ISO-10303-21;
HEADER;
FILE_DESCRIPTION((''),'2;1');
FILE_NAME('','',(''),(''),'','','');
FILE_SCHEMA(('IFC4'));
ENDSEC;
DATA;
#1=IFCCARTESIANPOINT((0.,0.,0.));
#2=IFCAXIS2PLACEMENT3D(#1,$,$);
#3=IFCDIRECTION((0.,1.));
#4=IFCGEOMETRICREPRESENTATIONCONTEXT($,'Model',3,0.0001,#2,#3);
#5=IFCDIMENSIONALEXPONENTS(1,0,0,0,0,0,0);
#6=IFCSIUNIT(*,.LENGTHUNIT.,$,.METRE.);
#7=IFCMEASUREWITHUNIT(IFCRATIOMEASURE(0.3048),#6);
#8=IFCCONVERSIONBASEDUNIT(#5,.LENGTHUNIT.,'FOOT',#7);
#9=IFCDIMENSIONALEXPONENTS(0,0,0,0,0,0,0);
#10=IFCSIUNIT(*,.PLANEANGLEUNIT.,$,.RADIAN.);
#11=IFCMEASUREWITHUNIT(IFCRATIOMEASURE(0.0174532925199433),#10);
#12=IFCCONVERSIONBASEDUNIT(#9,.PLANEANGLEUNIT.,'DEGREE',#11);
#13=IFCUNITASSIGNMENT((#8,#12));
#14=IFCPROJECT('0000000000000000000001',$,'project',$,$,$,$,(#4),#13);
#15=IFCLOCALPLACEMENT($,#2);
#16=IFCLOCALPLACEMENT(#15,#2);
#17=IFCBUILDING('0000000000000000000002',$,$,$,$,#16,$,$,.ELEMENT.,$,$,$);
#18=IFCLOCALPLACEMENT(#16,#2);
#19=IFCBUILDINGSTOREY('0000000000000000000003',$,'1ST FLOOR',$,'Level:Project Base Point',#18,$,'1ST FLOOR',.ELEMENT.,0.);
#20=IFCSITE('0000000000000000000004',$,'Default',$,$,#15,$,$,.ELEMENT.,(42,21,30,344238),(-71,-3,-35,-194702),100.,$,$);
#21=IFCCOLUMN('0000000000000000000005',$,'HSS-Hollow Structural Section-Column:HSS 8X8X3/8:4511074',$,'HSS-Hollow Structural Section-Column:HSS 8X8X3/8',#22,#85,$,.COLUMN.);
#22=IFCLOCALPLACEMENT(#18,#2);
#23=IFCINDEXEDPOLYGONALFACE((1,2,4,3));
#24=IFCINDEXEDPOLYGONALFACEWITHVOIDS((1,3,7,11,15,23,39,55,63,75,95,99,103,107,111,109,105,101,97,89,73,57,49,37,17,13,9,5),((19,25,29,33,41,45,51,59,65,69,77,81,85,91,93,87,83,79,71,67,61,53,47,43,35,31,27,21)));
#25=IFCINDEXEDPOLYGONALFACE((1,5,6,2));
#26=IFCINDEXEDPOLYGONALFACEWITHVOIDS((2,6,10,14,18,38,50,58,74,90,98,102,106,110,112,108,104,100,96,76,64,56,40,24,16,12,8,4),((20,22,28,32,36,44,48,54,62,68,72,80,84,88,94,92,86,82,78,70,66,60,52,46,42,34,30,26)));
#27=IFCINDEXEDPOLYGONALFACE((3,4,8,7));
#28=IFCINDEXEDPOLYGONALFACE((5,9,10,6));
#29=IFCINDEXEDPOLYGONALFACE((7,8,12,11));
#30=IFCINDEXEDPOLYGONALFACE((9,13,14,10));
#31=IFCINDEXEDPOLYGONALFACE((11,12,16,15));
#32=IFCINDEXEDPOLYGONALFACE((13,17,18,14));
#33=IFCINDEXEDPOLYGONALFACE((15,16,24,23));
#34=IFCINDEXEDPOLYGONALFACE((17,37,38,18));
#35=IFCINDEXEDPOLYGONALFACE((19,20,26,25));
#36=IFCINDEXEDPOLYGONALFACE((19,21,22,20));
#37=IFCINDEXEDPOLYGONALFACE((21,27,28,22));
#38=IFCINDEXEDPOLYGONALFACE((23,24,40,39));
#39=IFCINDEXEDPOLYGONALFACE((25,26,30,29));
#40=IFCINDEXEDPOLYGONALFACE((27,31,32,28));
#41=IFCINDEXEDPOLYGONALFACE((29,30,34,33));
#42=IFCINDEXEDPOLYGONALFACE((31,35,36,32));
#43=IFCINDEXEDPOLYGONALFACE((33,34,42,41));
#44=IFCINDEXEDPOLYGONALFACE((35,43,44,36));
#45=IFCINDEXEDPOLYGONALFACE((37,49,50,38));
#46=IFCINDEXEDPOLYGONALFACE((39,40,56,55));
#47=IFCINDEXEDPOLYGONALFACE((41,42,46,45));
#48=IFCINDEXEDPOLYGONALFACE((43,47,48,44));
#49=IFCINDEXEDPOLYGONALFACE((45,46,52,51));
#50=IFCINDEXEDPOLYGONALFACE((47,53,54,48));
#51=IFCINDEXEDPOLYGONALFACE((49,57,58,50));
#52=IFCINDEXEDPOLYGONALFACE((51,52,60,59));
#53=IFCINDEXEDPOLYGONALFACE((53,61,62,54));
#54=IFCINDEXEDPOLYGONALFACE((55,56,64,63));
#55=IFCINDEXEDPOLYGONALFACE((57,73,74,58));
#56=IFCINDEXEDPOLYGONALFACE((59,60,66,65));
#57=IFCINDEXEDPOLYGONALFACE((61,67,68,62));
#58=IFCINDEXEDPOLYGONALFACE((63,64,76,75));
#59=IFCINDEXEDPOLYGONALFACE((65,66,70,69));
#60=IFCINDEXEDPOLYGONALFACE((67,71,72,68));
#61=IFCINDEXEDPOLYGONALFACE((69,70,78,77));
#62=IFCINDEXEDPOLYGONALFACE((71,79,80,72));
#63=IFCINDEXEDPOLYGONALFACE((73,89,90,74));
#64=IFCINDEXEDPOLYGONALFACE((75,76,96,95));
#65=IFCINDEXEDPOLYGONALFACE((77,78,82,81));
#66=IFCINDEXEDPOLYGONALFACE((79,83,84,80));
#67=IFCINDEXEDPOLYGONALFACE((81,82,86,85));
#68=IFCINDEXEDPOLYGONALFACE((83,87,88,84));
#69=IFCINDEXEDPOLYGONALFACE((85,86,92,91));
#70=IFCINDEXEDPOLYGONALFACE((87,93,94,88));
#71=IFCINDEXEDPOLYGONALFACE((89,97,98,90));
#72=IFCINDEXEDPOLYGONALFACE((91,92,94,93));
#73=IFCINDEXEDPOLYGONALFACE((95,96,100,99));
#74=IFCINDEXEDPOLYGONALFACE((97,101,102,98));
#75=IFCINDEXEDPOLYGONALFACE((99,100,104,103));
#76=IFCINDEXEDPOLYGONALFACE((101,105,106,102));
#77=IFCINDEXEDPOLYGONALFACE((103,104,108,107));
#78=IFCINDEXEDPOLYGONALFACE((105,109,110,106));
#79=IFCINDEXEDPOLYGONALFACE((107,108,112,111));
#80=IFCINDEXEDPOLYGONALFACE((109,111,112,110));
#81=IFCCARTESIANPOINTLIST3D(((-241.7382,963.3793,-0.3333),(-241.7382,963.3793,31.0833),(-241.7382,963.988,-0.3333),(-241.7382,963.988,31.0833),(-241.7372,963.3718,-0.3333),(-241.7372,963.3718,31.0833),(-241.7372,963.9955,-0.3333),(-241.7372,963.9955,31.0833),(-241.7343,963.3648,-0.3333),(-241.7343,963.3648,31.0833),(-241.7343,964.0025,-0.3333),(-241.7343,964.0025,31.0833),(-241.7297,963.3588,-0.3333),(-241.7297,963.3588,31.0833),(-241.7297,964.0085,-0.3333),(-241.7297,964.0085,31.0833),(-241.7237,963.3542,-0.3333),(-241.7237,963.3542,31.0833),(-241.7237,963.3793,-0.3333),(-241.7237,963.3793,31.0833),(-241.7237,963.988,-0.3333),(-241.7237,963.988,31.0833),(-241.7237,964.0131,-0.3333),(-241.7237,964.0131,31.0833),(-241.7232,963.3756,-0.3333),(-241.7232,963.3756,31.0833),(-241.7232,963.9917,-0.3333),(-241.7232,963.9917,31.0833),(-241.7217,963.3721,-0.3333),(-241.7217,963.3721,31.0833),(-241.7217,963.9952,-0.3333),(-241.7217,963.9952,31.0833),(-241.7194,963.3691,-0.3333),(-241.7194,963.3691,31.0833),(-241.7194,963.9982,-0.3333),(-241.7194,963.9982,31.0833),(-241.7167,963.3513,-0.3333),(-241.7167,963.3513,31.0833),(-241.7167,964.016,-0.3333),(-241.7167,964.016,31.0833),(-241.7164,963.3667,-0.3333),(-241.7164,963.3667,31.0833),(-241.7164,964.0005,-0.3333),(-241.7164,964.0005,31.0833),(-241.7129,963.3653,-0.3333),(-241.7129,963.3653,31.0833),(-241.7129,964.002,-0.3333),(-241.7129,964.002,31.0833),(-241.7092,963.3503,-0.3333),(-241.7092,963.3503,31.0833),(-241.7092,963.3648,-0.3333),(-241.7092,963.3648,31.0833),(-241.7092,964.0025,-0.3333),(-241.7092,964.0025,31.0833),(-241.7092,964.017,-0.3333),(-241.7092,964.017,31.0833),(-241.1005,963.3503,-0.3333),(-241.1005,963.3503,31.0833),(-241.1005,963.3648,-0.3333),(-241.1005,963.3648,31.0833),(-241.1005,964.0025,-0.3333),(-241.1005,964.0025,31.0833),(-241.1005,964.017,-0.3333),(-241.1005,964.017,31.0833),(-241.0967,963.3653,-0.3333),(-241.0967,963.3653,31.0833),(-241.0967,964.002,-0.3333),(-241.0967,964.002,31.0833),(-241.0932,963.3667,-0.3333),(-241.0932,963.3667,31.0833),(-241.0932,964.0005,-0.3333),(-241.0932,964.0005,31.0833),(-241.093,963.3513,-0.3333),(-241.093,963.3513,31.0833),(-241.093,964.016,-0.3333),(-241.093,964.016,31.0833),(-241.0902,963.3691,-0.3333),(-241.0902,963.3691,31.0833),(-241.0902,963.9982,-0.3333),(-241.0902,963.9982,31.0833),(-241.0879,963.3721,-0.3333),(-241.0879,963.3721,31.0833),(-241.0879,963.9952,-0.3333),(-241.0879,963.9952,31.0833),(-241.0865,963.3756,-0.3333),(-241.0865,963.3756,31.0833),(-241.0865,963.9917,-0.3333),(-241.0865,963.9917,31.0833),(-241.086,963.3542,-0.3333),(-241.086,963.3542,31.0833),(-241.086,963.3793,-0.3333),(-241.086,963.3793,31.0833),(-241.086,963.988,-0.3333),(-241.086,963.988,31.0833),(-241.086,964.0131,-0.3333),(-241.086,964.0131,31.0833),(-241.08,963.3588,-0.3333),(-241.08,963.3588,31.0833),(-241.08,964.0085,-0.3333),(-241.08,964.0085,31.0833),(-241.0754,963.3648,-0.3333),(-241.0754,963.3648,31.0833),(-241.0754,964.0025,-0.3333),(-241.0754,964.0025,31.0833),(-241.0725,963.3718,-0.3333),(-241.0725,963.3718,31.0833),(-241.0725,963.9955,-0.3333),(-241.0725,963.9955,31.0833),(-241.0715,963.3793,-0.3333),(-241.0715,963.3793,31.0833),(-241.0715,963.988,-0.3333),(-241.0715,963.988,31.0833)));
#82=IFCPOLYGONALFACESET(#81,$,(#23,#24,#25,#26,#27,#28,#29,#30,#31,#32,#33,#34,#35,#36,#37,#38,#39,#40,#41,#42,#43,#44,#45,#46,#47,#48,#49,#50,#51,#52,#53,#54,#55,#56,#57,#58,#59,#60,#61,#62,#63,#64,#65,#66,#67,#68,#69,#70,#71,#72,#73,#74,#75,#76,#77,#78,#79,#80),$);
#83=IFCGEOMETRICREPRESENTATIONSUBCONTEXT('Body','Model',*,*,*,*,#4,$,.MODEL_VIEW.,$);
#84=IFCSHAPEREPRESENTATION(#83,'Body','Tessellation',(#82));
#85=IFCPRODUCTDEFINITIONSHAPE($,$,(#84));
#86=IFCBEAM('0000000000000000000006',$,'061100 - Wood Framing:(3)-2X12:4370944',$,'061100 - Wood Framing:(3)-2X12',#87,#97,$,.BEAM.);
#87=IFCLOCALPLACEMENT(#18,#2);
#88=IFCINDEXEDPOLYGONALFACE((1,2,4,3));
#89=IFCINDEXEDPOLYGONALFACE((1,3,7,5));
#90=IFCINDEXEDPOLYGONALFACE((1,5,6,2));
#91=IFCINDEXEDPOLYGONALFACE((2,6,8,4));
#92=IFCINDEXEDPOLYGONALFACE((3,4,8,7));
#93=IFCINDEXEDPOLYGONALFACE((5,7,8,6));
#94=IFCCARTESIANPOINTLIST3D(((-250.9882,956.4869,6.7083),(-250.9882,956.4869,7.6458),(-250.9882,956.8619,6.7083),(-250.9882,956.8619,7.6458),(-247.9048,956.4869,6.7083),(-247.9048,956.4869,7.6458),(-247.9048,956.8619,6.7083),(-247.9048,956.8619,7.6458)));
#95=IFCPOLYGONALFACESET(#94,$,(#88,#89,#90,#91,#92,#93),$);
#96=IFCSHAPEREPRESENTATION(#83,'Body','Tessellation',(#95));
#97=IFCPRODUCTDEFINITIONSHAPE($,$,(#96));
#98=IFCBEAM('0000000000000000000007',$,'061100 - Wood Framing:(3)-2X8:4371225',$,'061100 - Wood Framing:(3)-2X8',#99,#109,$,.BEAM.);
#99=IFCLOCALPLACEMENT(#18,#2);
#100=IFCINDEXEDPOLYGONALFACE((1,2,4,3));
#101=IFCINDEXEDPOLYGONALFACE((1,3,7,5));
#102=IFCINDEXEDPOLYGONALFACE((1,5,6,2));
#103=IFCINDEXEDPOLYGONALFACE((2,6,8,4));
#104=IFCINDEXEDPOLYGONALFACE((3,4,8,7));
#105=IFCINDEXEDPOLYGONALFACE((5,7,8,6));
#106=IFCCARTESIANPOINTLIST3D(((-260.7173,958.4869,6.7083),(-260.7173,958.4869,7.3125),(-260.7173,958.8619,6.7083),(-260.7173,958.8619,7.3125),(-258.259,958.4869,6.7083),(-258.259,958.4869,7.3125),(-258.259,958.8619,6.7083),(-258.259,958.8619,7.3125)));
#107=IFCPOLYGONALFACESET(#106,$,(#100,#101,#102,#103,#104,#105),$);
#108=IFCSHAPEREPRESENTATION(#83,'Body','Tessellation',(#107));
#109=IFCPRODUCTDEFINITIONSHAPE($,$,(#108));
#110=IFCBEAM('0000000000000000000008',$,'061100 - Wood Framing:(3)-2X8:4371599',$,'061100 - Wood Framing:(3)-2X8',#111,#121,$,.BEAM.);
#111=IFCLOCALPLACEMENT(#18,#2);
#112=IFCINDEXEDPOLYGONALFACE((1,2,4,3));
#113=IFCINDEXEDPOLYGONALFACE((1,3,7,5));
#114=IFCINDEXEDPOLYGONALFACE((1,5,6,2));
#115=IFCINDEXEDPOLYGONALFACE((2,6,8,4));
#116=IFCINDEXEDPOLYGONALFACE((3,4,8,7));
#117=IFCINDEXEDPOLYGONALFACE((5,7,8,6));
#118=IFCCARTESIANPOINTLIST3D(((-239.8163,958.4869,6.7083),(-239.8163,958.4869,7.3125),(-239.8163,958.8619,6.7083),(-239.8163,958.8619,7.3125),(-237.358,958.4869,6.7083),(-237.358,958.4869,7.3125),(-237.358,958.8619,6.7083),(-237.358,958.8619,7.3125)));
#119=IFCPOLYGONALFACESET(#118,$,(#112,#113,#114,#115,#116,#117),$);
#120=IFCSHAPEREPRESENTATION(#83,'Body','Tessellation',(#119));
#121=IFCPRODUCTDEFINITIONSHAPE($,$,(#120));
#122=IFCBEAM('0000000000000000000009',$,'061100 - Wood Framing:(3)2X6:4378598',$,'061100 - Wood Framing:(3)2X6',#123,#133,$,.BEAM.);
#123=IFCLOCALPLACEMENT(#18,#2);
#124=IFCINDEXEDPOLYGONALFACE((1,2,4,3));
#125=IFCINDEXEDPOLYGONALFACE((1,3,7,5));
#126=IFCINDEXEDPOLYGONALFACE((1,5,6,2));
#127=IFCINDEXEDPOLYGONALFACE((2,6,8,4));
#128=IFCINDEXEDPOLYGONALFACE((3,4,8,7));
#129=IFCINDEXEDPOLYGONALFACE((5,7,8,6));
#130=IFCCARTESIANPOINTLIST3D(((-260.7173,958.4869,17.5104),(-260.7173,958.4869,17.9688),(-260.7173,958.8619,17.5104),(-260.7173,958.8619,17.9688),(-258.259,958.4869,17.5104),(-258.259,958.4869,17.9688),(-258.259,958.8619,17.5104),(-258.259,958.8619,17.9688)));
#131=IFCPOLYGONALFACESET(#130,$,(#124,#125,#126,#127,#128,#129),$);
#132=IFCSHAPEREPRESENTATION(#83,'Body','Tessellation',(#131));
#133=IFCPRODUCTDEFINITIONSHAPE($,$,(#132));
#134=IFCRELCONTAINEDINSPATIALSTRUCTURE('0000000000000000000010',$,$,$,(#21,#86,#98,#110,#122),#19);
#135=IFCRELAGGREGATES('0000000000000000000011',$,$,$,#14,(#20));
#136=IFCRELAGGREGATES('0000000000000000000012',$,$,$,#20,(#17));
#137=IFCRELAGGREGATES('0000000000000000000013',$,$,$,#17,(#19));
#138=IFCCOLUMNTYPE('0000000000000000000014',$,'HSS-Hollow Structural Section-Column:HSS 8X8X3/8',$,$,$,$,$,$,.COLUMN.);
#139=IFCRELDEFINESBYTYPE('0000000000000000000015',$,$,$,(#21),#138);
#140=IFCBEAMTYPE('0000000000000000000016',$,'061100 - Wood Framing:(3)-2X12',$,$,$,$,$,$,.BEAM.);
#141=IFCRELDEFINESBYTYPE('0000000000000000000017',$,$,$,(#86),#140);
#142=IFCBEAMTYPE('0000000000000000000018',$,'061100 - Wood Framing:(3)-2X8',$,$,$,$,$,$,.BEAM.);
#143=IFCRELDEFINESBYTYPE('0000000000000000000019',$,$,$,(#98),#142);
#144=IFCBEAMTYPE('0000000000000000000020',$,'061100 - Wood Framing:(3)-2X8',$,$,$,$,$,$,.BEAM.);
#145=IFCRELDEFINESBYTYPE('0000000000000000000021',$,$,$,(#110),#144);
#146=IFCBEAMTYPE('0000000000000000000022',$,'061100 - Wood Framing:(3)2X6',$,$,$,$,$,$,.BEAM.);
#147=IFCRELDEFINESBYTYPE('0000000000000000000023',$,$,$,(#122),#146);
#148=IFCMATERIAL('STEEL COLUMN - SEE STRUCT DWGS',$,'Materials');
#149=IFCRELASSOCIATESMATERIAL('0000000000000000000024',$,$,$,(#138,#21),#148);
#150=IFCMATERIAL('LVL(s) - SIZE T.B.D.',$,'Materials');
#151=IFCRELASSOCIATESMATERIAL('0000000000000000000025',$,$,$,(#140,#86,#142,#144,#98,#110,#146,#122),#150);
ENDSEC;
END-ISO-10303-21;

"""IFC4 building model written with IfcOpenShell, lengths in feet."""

from ifc_helpers import new_model, entity, si_unit, converted_unit, direction, frame, frame_2d, origin, origin_2d_with_axis, place, context, subcontext, project, spatial, polyline, circle_curve, parameter, trimmed, segment, composite_curve, rectangle, outline, extrude, source, transform, mapped, material, material_profile, profile_set, profile_usage, type_object, type_shapes, element, save


model = new_model("IFC4")

# Units and contexts
model_context = context("Model", 3, precision=0.0001, world=origin(), true_north=direction((0.0, 1.0)))
body_context = subcontext(model_context, "Body", "Model", "MODEL_VIEW")
ifc_project = project(units=[converted_unit("LENGTHUNIT", "FOOT", entity("IfcRatioMeasure", 0.3048), si_unit("LENGTHUNIT", "METRE"), dimensions=[1, 0, 0, 0, 0, 0, 0]), converted_unit("PLANEANGLEUNIT", "DEGREE", entity("IfcRatioMeasure", 0.0174532925199433), si_unit("PLANEANGLEUNIT", "RADIAN"), dimensions=[0, 0, 0, 0, 0, 0, 0])], contexts=[model_context])

# Site, building, storey
site_placement = place(None, origin())
site = spatial("IfcSite", under=ifc_project, at=site_placement, Name="Default", CompositionType="ELEMENT", RefLatitude=(42, 21, 30, 344238), RefLongitude=(-71, -3, -35, -194702), RefElevation=100.0)
building_placement = place(site_placement, origin())
building = spatial("IfcBuilding", under=site, at=building_placement, CompositionType="ELEMENT")
storey_placement = place(building_placement, origin())
storey = spatial("IfcBuildingStorey", under=building, at=storey_placement, Name="1ST FLOOR", ObjectType="Level:Project Base Point", LongName="1ST FLOOR", CompositionType="ELEMENT", Elevation=0.0)

# Column
ifc_material_1 = material(Name="STEEL COLUMN - SEE STRUCT DWGS", Category="Materials")
ifc_material_profile_1 = material_profile(ifc_material_1, outline(composite_curve([segment(polyline([(-0.3043, -0.3333), (0.3043, -0.3333)]), True, "CONTINUOUS"), segment(trimmed(circle_curve(frame_2d((0.3043, -0.3043), x_axis=(-1.0, 0.0)), 0.029), [parameter(90.0)], [parameter(180.0)], True, "PARAMETER"), True, "CONTINUOUS"), segment(polyline([(0.3333, -0.3043), (0.3333, 0.3043)]), True, "CONTINUOUS"), segment(trimmed(circle_curve(frame_2d((0.3043, 0.3043), x_axis=(-1.0, 0.0)), 0.029), [parameter(180.0)], [parameter(270.0)], True, "PARAMETER"), True, "CONTINUOUS"), segment(polyline([(0.3043, 0.3333), (-0.3043, 0.3333)]), True, "CONTINUOUS"), segment(trimmed(circle_curve(frame_2d((-0.3043, 0.3043), x_axis=(-1.0, 0.0)), 0.029), [parameter(270.0)], [parameter(360.0)], True, "PARAMETER"), True, "CONTINUOUS"), segment(polyline([(-0.3333, 0.3043), (-0.3333, -0.3043)]), True, "CONTINUOUS"), segment(trimmed(circle_curve(frame_2d((-0.3043, -0.3043), x_axis=(-1.0, 0.0)), 0.029), [parameter(360.0)], [parameter(90.0)], True, "PARAMETER"), True, "CONTINUOUS")], self_intersect=False), holes=[composite_curve([segment(trimmed(circle_curve(frame_2d((-0.3043, -0.3043), x_axis=(-1.0, 0.0)), 0.0145), [parameter(0.0)], [parameter(90.0)], True, "PARAMETER"), False, "CONTINUOUS"), segment(polyline([(-0.3188, -0.3043), (-0.3188, 0.3043)]), True, "CONTINUOUS"), segment(trimmed(circle_curve(frame_2d((-0.3043, 0.3043), x_axis=(-1.0, 0.0)), 0.0145), [parameter(270.0)], [parameter(0.0)], True, "PARAMETER"), False, "CONTINUOUS"), segment(polyline([(-0.3043, 0.3188), (0.3043, 0.3188)]), True, "CONTINUOUS"), segment(trimmed(circle_curve(frame_2d((0.3043, 0.3043), x_axis=(-1.0, 0.0)), 0.0145), [parameter(180.0)], [parameter(270.0)], True, "PARAMETER"), False, "CONTINUOUS"), segment(polyline([(0.3188, 0.3043), (0.3188, -0.3043)]), True, "CONTINUOUS"), segment(trimmed(circle_curve(frame_2d((0.3043, -0.3043), x_axis=(-1.0, 0.0)), 0.0145), [parameter(90.0)], [parameter(180.0)], True, "PARAMETER"), False, "CONTINUOUS"), segment(polyline([(0.3043, -0.3188), (-0.3043, -0.3188)]), True, "CONTINUOUS")], self_intersect=False)]), Name="HSS 8X8X3/8")
ifc_profile_set_1 = profile_set([ifc_material_profile_1], Name="HSS 8X8X3/8")
ifc_profile_usage_1 = profile_usage(ifc_profile_set_1)
column_type_1 = type_object("IfcColumnType", Name="HSS-Hollow Structural Section-Column:HSS 8X8X3/8", PredefinedType="COLUMN", material=ifc_profile_set_1)
shared_shape_1 = source(origin(), body_context, "Body", "SweptSolid", [
    extrude(outline(composite_curve([segment(trimmed(circle_curve(frame_2d((0.3043, -0.3043), x_axis=(1.0, 0.0)), 0.029), [parameter(270.0)], [parameter(0.0)], True, "PARAMETER"), True, "CONTINUOUS"), segment(polyline([(0.3333, -0.3043), (0.3333, 0.3043)]), True, "CONTINUOUS"), segment(trimmed(circle_curve(frame_2d((0.3043, 0.3043), x_axis=(1.0, 0.0)), 0.029), [parameter(0.0)], [parameter(90.0)], True, "PARAMETER"), True, "CONTINUOUS"), segment(polyline([(0.3043, 0.3333), (-0.3043, 0.3333)]), True, "CONTINUOUS"), segment(trimmed(circle_curve(frame_2d((-0.3043, 0.3043), x_axis=(1.0, 0.0)), 0.029), [parameter(90.0)], [parameter(180.0)], True, "PARAMETER"), True, "CONTINUOUS"), segment(polyline([(-0.3333, 0.3043), (-0.3333, -0.3043)]), True, "CONTINUOUS"), segment(trimmed(circle_curve(frame_2d((-0.3043, -0.3043), x_axis=(1.0, 0.0)), 0.029), [parameter(180.0)], [parameter(270.0)], True, "PARAMETER"), True, "CONTINUOUS"), segment(polyline([(-0.3043, -0.3333), (0.3043, -0.3333)]), True, "CONTINUOUS")], self_intersect=False), holes=[composite_curve([segment(polyline([(0.3043, -0.3188), (-0.3043, -0.3188)]), True, "CONTINUOUS"), segment(trimmed(circle_curve(frame_2d((-0.3043, -0.3043), x_axis=(1.0, 0.0)), 0.0145), [parameter(180.0)], [parameter(270.0)], True, "PARAMETER"), False, "CONTINUOUS"), segment(polyline([(-0.3188, -0.3043), (-0.3188, 0.3043)]), True, "CONTINUOUS"), segment(trimmed(circle_curve(frame_2d((-0.3043, 0.3043), x_axis=(1.0, 0.0)), 0.0145), [parameter(90.0)], [parameter(180.0)], True, "PARAMETER"), False, "CONTINUOUS"), segment(polyline([(-0.3043, 0.3188), (0.3043, 0.3188)]), True, "CONTINUOUS"), segment(trimmed(circle_curve(frame_2d((0.3043, 0.3043), x_axis=(1.0, 0.0)), 0.0145), [parameter(0.0)], [parameter(90.0)], True, "PARAMETER"), False, "CONTINUOUS"), segment(polyline([(0.3188, 0.3043), (0.3188, -0.3043)]), True, "CONTINUOUS"), segment(trimmed(circle_curve(frame_2d((0.3043, -0.3043), x_axis=(1.0, 0.0)), 0.0145), [parameter(270.0)], [parameter(0.0)], True, "PARAMETER"), False, "CONTINUOUS")], self_intersect=False)]), frame((0.0, 0.0, -0.3333)), (0.0, 0.0, 1.0), 31.4167),
])
type_shapes(column_type_1, [shared_shape_1])
column_1_placement = place(storey_placement, frame((-241.4048, 963.6836, 0.0), z_axis=(0.0, 0.0, 1.0), x_axis=(-1.0, 0.0, 0.0)))
element("IfcColumn", 1, at=column_1_placement, inside=storey, type_object=column_type_1, material=ifc_profile_usage_1, Name="HSS-Hollow Structural Section-Column:HSS 8X8X3/8:4511074", ObjectType="HSS-Hollow Structural Section-Column:HSS 8X8X3/8", PredefinedType="COLUMN", context=body_context, shape_type="MappedRepresentation", body=[
    mapped(shared_shape_1, transform((0.0, 0.0, 0.0), scale=1.0)),
])

# Beams
ifc_material_2 = material(Name="LVL(s) - SIZE T.B.D.", Category="Materials")
ifc_material_profile_2 = material_profile(ifc_material_2, rectangle(XDim=0.9375, YDim=0.375, at=frame_2d((0.0, 0.0), x_axis=(1.0, 0.0))), Name="(3)-2X12")
ifc_profile_set_2 = profile_set([ifc_material_profile_2], Name="(3)-2X12")
ifc_profile_usage_2 = profile_usage(ifc_profile_set_2, cardinal=8)
beam_type_1 = type_object("IfcBeamType", Name="061100 - Wood Framing:(3)-2X12", PredefinedType="BEAM", material=ifc_profile_set_2)
shared_shape_2 = source(origin(), body_context, "Body", "SweptSolid", [
    extrude(rectangle(XDim=0.9375, YDim=0.375, at=frame_2d((0.0, 0.0), x_axis=(1.0, 0.0))), frame((-1.5937, 0.0, 0.0), z_axis=(1.0, 0.0, 0.0), x_axis=(0.0, 0.0, -1.0)), (0.0, 0.0, 1.0), 3.0833),
])
type_shapes(beam_type_1, [shared_shape_2])
beam_1_placement = place(storey_placement, frame((-249.3944, 956.6744, 7.1771)))
element("IfcBeam", 2, at=beam_1_placement, inside=storey, type_object=beam_type_1, material=ifc_profile_usage_2, Name="061100 - Wood Framing:(3)-2X12:4370944", ObjectType="061100 - Wood Framing:(3)-2X12", PredefinedType="BEAM", context=body_context, shape_type="MappedRepresentation", body=[
    mapped(shared_shape_2, transform((0.0, 0.0, 0.0), scale=1.0)),
])
ifc_material_profile_3 = material_profile(ifc_material_2, rectangle(XDim=0.6042, YDim=0.375, at=frame_2d((0.0, 0.0), x_axis=(1.0, 0.0))), Name="(3)-2X8")
ifc_profile_set_3 = profile_set([ifc_material_profile_3], Name="(3)-2X8")
ifc_profile_usage_3 = profile_usage(ifc_profile_set_3, cardinal=8)
beam_type_2 = type_object("IfcBeamType", Name="061100 - Wood Framing:(3)-2X8", PredefinedType="BEAM", material=ifc_profile_set_3)
shared_shape_3 = source(origin(), body_context, "Body", "SweptSolid", [
    extrude(rectangle(XDim=0.6042, YDim=0.375, at=frame_2d((0.0, 0.0), x_axis=(1.0, 0.0))), frame((-1.2203, 0.0, 0.0), z_axis=(1.0, 0.0, 0.0), x_axis=(0.0, 0.0, -1.0)), (0.0, 0.0, 1.0), 2.4583),
])
type_shapes(beam_type_2, [shared_shape_3])
beam_2_placement = place(storey_placement, frame((-259.497, 958.6744, 7.0104)))
element("IfcBeam", 3, at=beam_2_placement, inside=storey, type_object=beam_type_2, material=ifc_profile_usage_3, Name="061100 - Wood Framing:(3)-2X8:4371225", ObjectType="061100 - Wood Framing:(3)-2X8", PredefinedType="BEAM", context=body_context, shape_type="MappedRepresentation", body=[
    mapped(shared_shape_3, transform((0.0, 0.0, 0.0), scale=1.0)),
])
ifc_profile_usage_4 = profile_usage(ifc_profile_set_3, cardinal=8)
beam_type_3 = type_object("IfcBeamType", Name="061100 - Wood Framing:(3)-2X8", PredefinedType="BEAM", material=ifc_profile_set_3)
shared_shape_4 = source(origin(), body_context, "Body", "SweptSolid", [
    extrude(rectangle(XDim=0.6042, YDim=0.375, at=frame_2d((0.0, 0.0), x_axis=(1.0, 0.0))), frame((-1.2371, 0.0, 0.0), z_axis=(1.0, 0.0, 0.0), x_axis=(0.0, 0.0, -1.0)), (0.0, 0.0, 1.0), 2.4583),
])
type_shapes(beam_type_3, [shared_shape_4])
beam_3_placement = place(storey_placement, frame((-238.5792, 958.6744, 7.0104)))
element("IfcBeam", 4, at=beam_3_placement, inside=storey, type_object=beam_type_3, material=ifc_profile_usage_4, Name="061100 - Wood Framing:(3)-2X8:4371599", ObjectType="061100 - Wood Framing:(3)-2X8", PredefinedType="BEAM", context=body_context, shape_type="MappedRepresentation", body=[
    mapped(shared_shape_4, transform((0.0, 0.0, 0.0), scale=1.0)),
])
ifc_material_profile_4 = material_profile(ifc_material_2, rectangle(XDim=0.4583, YDim=0.375, at=frame_2d((0.0, 0.0), x_axis=(1.0, 0.0))), Name="(3)2X6")
ifc_profile_set_4 = profile_set([ifc_material_profile_4], Name="(3)2X6")
ifc_profile_usage_5 = profile_usage(ifc_profile_set_4, cardinal=8)
beam_type_4 = type_object("IfcBeamType", Name="061100 - Wood Framing:(3)2X6", PredefinedType="BEAM", material=ifc_profile_set_4)
shared_shape_5 = source(origin(), body_context, "Body", "SweptSolid", [
    extrude(rectangle(XDim=0.4583, YDim=0.375, at=origin_2d_with_axis()), frame((-1.2155, 0.0, 0.0), z_axis=(1.0, 0.0, 0.0), x_axis=(0.0, 0.0, -1.0)), (0.0, 0.0, 1.0), 2.4583),
])
type_shapes(beam_type_4, [shared_shape_5])
beam_4_placement = place(storey_placement, frame((-259.5019, 958.6744, 17.7396)))
element("IfcBeam", 5, at=beam_4_placement, inside=storey, type_object=beam_type_4, material=ifc_profile_usage_5, Name="061100 - Wood Framing:(3)2X6:4378598", ObjectType="061100 - Wood Framing:(3)2X6", PredefinedType="BEAM", context=body_context, shape_type="MappedRepresentation", body=[
    mapped(shared_shape_5, transform((0.0, 0.0, 0.0), scale=1.0)),
])

save(model, "model.ifc")
